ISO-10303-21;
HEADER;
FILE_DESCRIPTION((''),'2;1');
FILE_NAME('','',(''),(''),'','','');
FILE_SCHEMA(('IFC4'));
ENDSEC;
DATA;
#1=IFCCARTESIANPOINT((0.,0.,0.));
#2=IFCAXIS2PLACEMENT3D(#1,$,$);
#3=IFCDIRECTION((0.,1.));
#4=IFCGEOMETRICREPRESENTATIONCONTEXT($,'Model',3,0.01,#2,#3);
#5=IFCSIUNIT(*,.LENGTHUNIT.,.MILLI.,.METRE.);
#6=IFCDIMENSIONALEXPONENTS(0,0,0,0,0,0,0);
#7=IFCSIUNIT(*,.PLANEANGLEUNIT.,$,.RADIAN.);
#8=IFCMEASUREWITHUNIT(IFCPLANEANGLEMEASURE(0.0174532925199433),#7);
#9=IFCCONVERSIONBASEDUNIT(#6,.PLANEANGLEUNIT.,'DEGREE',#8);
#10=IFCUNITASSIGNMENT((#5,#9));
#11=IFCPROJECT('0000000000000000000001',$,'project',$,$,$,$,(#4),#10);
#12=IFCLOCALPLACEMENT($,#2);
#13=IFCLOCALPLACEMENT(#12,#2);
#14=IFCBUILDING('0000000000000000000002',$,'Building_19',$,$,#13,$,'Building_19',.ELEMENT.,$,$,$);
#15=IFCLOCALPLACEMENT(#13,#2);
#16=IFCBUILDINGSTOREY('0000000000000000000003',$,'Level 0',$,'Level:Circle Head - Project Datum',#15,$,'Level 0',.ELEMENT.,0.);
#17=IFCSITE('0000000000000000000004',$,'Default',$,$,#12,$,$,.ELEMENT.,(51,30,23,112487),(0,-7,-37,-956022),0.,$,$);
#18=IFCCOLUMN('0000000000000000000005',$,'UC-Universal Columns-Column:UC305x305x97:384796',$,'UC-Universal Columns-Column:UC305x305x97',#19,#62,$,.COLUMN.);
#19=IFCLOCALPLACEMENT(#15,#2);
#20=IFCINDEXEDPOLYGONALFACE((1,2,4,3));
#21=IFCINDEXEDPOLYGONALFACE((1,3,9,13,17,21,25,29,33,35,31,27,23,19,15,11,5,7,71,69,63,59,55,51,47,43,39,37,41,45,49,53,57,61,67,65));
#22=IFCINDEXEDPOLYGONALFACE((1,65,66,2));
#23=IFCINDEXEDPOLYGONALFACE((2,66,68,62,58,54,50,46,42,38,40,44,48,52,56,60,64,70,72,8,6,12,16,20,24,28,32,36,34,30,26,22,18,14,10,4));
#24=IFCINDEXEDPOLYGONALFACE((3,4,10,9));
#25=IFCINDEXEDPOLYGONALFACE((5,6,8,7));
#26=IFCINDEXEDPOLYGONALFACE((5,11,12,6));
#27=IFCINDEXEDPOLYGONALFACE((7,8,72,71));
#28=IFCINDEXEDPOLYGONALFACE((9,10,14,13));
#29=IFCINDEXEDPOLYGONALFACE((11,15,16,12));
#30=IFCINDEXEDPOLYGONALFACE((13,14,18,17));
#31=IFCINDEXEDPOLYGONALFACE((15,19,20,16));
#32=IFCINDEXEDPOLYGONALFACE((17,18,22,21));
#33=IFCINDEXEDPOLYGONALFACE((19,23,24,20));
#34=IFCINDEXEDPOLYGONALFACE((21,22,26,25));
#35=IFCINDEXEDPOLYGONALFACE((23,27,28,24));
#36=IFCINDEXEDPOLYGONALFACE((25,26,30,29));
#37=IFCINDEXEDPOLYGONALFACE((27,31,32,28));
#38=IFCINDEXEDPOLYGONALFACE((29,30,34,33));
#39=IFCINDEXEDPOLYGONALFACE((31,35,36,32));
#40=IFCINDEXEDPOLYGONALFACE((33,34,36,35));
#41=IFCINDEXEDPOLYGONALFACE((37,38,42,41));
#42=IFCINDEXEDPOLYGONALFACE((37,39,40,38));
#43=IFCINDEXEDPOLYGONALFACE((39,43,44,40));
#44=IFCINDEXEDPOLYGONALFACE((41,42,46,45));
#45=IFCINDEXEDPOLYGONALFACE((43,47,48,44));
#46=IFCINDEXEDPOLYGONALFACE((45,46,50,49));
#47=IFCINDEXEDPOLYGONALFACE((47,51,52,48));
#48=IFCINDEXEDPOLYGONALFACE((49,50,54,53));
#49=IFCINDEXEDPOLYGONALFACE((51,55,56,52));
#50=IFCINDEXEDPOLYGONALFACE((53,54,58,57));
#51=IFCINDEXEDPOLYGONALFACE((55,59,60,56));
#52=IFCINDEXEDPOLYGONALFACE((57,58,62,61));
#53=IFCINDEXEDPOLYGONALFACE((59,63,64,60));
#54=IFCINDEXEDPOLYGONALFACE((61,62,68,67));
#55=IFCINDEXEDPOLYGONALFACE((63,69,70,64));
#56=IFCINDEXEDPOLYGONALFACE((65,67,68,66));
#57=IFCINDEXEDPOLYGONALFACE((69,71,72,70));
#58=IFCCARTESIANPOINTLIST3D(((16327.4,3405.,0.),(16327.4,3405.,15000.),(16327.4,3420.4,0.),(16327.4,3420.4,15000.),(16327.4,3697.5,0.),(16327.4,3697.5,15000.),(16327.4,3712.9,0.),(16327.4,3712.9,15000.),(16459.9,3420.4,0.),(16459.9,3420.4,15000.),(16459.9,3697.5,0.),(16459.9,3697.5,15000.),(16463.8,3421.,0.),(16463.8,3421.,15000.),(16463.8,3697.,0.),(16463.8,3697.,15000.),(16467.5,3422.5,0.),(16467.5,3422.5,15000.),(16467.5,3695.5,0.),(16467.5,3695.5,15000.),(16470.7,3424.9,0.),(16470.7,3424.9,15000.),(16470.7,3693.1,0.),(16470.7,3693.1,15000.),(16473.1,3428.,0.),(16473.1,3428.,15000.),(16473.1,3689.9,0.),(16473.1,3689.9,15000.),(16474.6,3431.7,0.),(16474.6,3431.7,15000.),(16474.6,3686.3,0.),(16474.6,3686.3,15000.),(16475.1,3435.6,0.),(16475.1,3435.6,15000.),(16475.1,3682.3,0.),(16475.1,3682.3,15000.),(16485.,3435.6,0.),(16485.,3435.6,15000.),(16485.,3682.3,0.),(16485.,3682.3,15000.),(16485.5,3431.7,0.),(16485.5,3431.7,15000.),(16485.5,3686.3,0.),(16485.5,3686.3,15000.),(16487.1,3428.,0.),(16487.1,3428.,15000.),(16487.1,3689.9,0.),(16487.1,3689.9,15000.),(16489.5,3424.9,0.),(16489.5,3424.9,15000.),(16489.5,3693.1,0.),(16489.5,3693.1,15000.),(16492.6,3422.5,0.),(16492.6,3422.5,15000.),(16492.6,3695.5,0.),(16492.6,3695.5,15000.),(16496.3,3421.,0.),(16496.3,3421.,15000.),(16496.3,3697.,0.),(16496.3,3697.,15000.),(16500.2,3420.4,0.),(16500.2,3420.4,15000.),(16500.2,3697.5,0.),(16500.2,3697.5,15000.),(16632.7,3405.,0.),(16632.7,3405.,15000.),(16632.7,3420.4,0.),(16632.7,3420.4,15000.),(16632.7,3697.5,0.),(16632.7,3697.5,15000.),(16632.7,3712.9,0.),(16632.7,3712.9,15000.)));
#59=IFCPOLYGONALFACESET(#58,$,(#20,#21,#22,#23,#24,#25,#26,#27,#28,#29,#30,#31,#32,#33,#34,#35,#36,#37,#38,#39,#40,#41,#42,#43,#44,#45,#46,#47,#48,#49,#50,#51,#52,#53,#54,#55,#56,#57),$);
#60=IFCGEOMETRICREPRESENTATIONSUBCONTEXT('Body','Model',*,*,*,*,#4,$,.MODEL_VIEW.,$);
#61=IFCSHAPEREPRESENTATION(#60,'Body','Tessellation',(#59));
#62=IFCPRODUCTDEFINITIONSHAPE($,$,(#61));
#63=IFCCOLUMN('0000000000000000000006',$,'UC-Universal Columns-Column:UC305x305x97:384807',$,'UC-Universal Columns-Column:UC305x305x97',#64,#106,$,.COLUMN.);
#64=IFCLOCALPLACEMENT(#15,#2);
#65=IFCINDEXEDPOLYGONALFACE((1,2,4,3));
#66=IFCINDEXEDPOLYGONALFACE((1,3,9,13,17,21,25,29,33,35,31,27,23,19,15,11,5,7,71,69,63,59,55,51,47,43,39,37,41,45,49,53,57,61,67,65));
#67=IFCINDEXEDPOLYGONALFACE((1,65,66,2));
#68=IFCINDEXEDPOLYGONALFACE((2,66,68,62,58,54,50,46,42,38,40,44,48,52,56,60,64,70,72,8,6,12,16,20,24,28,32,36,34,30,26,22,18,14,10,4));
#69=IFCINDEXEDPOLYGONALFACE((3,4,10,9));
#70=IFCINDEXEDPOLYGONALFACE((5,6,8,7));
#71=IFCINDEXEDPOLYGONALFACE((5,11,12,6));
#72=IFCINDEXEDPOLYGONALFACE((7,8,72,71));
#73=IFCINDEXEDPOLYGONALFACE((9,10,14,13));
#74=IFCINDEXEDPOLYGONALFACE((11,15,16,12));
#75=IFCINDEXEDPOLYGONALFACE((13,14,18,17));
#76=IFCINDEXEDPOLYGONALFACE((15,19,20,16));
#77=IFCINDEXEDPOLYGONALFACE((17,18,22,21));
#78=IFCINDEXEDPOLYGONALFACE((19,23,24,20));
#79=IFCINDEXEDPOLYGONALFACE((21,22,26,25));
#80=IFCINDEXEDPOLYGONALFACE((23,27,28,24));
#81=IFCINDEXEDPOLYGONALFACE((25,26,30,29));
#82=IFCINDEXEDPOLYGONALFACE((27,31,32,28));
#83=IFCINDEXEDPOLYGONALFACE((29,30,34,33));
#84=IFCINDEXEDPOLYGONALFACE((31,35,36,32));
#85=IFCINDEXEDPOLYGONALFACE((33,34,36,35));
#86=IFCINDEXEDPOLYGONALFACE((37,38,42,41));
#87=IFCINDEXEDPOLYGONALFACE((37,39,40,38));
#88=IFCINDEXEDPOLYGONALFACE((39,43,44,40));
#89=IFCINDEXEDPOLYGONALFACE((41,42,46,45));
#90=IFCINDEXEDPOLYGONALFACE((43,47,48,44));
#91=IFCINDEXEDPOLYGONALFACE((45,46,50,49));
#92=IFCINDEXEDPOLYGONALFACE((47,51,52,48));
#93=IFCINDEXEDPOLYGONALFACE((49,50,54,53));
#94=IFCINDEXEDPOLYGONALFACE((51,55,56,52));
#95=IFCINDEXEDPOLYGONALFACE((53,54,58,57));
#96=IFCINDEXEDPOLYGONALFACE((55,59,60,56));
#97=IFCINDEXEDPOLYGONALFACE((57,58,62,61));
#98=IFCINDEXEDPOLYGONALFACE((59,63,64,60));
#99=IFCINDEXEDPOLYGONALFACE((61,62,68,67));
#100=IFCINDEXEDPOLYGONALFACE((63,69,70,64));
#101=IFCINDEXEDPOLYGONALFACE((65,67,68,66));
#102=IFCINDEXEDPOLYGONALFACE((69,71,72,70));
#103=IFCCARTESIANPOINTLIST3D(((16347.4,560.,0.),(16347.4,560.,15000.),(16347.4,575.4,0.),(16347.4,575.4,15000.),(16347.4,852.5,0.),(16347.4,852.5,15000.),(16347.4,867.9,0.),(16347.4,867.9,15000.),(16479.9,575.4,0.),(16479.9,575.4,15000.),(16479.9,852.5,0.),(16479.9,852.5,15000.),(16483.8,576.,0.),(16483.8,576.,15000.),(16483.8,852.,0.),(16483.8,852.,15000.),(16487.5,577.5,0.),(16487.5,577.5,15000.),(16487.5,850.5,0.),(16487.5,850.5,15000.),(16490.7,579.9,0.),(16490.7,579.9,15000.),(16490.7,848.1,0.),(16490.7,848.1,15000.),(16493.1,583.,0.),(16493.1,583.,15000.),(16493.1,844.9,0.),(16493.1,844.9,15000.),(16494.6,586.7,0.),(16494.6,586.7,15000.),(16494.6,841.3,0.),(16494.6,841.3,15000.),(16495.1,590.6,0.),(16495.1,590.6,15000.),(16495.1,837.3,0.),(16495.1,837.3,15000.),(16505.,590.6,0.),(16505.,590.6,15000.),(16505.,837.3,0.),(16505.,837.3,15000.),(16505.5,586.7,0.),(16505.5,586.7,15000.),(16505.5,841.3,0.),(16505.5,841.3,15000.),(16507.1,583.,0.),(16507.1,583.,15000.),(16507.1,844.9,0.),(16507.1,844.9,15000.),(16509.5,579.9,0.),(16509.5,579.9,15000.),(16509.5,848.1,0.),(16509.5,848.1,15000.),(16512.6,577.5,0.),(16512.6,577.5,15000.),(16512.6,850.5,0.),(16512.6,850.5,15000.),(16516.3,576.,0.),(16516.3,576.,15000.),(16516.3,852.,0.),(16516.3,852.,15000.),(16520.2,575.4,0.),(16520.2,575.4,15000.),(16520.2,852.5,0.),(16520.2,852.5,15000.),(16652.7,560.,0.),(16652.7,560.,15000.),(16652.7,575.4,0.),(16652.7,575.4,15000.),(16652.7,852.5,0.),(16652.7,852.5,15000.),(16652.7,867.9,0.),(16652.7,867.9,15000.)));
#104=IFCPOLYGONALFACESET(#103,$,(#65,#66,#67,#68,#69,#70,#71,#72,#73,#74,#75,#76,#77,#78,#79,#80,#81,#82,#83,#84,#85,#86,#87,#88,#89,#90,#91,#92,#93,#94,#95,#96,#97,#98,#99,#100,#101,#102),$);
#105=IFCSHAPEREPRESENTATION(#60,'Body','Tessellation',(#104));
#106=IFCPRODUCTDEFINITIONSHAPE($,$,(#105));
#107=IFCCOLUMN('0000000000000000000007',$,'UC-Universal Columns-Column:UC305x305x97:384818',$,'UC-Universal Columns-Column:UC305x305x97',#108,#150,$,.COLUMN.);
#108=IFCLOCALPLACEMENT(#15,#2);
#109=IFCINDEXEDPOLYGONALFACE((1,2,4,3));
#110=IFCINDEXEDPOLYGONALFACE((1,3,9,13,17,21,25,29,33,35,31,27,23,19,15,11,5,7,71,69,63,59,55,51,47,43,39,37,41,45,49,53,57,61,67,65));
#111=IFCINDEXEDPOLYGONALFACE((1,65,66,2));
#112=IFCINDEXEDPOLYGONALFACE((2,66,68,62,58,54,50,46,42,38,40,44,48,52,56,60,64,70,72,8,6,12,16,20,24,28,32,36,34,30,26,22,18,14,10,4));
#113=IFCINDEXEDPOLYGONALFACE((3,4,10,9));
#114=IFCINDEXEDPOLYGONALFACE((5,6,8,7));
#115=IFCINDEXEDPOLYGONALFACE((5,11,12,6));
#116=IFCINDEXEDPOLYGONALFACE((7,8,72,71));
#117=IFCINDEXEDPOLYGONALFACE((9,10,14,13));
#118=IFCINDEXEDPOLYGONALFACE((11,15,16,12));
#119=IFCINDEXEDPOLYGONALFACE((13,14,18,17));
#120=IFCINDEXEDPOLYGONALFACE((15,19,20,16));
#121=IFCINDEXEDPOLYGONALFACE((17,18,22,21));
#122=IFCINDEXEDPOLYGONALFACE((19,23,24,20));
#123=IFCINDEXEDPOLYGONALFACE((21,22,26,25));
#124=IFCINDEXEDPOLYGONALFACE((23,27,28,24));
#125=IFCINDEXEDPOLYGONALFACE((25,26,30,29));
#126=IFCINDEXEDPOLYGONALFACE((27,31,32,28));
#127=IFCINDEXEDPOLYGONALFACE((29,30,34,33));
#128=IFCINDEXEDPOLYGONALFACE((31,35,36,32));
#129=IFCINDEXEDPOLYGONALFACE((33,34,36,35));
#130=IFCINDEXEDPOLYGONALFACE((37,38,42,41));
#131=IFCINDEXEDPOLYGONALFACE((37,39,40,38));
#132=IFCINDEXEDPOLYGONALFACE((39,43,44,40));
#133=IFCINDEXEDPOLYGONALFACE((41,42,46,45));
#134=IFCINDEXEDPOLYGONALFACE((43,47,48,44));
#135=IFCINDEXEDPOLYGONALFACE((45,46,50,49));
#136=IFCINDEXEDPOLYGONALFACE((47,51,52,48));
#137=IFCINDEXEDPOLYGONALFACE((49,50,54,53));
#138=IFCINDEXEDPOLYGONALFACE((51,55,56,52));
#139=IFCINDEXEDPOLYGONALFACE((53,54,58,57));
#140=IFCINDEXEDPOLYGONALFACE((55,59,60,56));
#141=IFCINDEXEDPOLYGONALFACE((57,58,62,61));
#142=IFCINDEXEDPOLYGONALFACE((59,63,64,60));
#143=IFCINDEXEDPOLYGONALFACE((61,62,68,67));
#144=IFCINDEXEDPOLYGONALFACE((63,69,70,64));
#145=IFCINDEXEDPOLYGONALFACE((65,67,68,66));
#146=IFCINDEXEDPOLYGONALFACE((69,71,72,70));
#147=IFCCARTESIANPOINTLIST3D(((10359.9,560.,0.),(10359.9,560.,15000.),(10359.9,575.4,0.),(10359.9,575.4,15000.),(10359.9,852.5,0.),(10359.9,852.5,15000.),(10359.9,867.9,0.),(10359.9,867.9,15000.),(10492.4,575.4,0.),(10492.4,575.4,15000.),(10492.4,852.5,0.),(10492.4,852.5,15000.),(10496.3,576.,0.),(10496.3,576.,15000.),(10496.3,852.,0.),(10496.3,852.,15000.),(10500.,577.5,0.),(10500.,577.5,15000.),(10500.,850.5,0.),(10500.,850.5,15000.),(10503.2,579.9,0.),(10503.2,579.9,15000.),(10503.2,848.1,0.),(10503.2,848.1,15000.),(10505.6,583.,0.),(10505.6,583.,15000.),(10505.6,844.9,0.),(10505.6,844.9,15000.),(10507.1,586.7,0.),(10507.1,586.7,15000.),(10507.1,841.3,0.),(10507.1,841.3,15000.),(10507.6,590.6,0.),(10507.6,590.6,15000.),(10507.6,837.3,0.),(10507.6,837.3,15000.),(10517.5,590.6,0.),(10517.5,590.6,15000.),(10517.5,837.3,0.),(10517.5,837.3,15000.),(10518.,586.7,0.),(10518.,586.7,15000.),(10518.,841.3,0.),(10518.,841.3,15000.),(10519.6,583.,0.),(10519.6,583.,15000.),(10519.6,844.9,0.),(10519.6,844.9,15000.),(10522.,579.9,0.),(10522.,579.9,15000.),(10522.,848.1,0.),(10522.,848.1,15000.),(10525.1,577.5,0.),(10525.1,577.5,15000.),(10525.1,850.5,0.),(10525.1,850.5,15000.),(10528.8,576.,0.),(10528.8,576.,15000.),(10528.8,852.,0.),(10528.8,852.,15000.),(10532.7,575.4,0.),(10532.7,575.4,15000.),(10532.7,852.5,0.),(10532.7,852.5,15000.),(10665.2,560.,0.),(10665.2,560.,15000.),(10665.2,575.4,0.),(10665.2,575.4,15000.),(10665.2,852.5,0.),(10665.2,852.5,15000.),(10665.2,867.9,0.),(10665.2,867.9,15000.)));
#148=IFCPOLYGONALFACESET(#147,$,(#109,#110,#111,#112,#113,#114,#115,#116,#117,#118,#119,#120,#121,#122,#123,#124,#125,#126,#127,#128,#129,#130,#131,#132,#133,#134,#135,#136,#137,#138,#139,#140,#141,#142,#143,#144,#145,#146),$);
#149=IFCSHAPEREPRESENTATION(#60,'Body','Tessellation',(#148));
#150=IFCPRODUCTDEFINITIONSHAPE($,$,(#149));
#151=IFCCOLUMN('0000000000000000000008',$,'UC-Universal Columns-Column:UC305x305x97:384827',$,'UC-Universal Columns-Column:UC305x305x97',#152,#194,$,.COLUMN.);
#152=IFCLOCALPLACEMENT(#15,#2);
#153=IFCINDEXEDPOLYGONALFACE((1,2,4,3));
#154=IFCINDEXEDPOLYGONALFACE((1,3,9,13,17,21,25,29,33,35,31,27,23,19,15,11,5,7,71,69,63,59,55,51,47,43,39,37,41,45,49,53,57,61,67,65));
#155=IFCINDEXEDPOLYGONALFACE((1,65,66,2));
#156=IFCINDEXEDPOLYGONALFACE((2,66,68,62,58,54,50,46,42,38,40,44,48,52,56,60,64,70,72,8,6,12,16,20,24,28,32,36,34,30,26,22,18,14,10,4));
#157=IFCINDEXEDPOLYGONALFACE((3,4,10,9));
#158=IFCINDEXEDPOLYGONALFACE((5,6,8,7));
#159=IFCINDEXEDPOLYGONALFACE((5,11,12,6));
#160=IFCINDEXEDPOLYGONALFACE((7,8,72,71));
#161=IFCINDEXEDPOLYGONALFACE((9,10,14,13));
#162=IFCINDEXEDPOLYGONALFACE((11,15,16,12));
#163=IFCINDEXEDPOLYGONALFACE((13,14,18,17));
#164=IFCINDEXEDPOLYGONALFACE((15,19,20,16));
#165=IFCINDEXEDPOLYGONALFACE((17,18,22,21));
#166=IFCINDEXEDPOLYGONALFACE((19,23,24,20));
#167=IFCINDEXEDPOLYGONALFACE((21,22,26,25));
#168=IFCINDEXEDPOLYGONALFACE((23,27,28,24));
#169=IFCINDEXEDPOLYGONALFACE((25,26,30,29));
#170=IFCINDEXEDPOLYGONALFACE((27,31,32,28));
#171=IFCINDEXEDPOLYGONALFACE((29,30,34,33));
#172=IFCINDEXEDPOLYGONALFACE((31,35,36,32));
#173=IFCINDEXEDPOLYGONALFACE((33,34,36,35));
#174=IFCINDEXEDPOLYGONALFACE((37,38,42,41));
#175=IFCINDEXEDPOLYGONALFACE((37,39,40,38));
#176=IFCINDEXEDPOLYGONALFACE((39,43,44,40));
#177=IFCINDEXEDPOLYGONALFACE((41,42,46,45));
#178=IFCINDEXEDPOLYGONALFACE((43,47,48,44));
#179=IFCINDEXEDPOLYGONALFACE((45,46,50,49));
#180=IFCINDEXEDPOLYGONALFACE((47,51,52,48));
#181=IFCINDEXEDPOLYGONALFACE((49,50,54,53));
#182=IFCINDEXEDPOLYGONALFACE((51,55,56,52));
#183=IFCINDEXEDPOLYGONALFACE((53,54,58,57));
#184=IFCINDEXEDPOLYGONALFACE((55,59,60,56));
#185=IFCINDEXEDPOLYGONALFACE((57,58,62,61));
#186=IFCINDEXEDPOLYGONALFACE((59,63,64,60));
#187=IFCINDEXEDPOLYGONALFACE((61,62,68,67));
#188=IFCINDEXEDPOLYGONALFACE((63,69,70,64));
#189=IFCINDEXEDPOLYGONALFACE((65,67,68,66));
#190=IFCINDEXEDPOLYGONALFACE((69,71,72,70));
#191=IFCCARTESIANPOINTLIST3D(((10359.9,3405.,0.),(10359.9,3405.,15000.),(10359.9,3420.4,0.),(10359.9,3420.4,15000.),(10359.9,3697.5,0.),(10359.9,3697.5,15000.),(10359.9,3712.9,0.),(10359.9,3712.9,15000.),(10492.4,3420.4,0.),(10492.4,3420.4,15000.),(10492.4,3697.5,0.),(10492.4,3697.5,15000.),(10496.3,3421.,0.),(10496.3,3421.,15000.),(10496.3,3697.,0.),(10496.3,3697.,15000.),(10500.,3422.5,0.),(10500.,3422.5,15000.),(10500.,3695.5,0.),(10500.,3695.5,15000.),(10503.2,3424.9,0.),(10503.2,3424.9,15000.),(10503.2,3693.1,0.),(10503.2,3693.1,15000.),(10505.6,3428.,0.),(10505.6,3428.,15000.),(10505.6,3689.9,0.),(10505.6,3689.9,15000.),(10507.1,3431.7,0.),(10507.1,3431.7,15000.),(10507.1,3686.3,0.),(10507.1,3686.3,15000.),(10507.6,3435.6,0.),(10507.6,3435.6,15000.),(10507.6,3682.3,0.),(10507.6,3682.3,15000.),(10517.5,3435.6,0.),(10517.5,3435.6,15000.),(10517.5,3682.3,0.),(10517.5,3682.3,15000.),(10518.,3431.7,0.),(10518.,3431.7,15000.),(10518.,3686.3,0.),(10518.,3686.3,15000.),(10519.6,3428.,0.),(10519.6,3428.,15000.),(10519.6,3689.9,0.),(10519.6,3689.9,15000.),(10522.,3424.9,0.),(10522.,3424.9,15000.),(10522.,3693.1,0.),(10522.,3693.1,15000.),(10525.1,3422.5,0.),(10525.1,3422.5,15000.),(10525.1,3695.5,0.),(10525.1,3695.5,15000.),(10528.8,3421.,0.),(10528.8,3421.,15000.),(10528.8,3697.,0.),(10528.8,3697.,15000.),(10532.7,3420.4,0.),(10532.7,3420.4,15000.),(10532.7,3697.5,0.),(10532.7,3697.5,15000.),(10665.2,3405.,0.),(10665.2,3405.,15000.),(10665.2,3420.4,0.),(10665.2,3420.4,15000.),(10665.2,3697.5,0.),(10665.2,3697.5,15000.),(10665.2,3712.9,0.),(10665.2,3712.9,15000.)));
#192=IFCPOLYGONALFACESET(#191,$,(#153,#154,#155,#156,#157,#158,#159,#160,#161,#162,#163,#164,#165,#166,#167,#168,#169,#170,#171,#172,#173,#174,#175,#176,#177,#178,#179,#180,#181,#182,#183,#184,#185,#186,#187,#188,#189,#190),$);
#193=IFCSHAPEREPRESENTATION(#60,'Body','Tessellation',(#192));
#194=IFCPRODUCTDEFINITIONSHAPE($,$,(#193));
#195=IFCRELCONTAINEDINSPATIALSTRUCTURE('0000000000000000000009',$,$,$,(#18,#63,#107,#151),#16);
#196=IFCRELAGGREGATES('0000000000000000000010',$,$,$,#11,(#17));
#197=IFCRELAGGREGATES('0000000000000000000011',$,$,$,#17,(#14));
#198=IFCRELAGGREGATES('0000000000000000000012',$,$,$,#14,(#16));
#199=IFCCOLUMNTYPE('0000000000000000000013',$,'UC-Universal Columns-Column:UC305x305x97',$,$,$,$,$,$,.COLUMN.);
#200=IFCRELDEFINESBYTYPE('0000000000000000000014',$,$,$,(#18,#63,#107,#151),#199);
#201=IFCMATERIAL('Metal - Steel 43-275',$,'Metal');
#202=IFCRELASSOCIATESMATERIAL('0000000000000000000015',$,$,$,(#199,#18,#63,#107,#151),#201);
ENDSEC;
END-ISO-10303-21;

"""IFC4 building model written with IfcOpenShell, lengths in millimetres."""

from ifc_helpers import new_model, entity, si_unit, converted_unit, direction, frame, origin, place, context, subcontext, project, spatial, line, arc, indexed_curve, outline, extrude, source, transform, mapped, material, type_object, type_shapes, element, save


model = new_model("IFC4")

# Units and contexts
model_context = context("Model", 3, precision=0.01, world=origin(), true_north=direction((0.0, 1.0)))
body_context = subcontext(model_context, "Body", "Model", "MODEL_VIEW")
ifc_project = project(units=[si_unit("LENGTHUNIT", "METRE", prefix="MILLI"), converted_unit("PLANEANGLEUNIT", "DEGREE", entity("IfcPlaneAngleMeasure", 0.0174532925199433), si_unit("PLANEANGLEUNIT", "RADIAN"), dimensions=[0, 0, 0, 0, 0, 0, 0])], contexts=[model_context])

# Site, building, storey
site_placement = place(None, origin())
site = spatial("IfcSite", under=ifc_project, at=site_placement, Name="Default", CompositionType="ELEMENT", RefLatitude=(51, 30, 23, 112487), RefLongitude=(0, -7, -37, -956022), RefElevation=0.0)
building_placement = place(site_placement, origin())
building = spatial("IfcBuilding", under=site, at=building_placement, Name="Building_19", LongName="Building_19", CompositionType="ELEMENT")
storey_placement = place(building_placement, origin())
storey = spatial("IfcBuildingStorey", under=building, at=storey_placement, Name="Level 0", ObjectType="Level:Circle Head - Project Datum", LongName="Level 0", CompositionType="ELEMENT", Elevation=0.0)

# Columns
ifc_material_1 = material(Name="Metal - Steel 43-275", Category="Metal")
column_type = type_object("IfcColumnType", Name="UC-Universal Columns-Column:UC305x305x97", PredefinedType="COLUMN", material=ifc_material_1)
shared_shape_1 = source(origin(), body_context, "Body", "SweptSolid", [
    extrude(outline(indexed_curve([(-152.7, -153.9), (152.7, -153.9), (152.7, -138.6), (20.2, -138.6), (9.4, -134.1), (4.9, -123.3), (4.9, 123.3), (9.4, 134.1), (20.1, 138.6), (152.7, 138.6), (152.7, 153.9), (-152.7, 153.9), (-152.7, 138.6), (-20.2, 138.6), (-9.4, 134.1), (-5.0, 123.3), (-5.0, -123.3), (-9.4, -134.1), (-20.2, -138.6), (-152.7, -138.6)], segments=[line(1, 2, 3, 4), arc(4, 5, 6), line(6, 7), arc(7, 8, 9), line(9, 10, 11, 12, 13, 14), arc(14, 15, 16), line(16, 17), arc(17, 18, 19), line(19, 20, 1)], self_intersect=False)), frame((0.0, 0.0, 0.0), z_axis=(0.0, 0.0, 1.0), x_axis=(-1.0, 0.0, 0.0)), (0.0, 0.0, 1.0), 15000.0),
])
type_shapes(column_type, [shared_shape_1])
for number, where, name in (
    (1, (16480.1, 3559.0, 0.0), "UC-Universal Columns-Column:UC305x305x97:384796"),
    (2, (16500.1, 714.0, 0.0), "UC-Universal Columns-Column:UC305x305x97:384807"),
    (3, (10512.6, 714.0, 0.0), "UC-Universal Columns-Column:UC305x305x97:384818"),
    (4, (10512.6, 3559.0, 0.0), "UC-Universal Columns-Column:UC305x305x97:384827"),
):
    element("IfcColumn", number, at=place(storey_placement, frame(where)), inside=storey, type_object=column_type, material=ifc_material_1, Name=name, ObjectType="UC-Universal Columns-Column:UC305x305x97", PredefinedType="COLUMN", context=body_context, shape_type="MappedRepresentation", body=[
        mapped(shared_shape_1, transform((0.0, 0.0, 0.0), scale=1.0)),
    ])

save(model, "model.ifc")
